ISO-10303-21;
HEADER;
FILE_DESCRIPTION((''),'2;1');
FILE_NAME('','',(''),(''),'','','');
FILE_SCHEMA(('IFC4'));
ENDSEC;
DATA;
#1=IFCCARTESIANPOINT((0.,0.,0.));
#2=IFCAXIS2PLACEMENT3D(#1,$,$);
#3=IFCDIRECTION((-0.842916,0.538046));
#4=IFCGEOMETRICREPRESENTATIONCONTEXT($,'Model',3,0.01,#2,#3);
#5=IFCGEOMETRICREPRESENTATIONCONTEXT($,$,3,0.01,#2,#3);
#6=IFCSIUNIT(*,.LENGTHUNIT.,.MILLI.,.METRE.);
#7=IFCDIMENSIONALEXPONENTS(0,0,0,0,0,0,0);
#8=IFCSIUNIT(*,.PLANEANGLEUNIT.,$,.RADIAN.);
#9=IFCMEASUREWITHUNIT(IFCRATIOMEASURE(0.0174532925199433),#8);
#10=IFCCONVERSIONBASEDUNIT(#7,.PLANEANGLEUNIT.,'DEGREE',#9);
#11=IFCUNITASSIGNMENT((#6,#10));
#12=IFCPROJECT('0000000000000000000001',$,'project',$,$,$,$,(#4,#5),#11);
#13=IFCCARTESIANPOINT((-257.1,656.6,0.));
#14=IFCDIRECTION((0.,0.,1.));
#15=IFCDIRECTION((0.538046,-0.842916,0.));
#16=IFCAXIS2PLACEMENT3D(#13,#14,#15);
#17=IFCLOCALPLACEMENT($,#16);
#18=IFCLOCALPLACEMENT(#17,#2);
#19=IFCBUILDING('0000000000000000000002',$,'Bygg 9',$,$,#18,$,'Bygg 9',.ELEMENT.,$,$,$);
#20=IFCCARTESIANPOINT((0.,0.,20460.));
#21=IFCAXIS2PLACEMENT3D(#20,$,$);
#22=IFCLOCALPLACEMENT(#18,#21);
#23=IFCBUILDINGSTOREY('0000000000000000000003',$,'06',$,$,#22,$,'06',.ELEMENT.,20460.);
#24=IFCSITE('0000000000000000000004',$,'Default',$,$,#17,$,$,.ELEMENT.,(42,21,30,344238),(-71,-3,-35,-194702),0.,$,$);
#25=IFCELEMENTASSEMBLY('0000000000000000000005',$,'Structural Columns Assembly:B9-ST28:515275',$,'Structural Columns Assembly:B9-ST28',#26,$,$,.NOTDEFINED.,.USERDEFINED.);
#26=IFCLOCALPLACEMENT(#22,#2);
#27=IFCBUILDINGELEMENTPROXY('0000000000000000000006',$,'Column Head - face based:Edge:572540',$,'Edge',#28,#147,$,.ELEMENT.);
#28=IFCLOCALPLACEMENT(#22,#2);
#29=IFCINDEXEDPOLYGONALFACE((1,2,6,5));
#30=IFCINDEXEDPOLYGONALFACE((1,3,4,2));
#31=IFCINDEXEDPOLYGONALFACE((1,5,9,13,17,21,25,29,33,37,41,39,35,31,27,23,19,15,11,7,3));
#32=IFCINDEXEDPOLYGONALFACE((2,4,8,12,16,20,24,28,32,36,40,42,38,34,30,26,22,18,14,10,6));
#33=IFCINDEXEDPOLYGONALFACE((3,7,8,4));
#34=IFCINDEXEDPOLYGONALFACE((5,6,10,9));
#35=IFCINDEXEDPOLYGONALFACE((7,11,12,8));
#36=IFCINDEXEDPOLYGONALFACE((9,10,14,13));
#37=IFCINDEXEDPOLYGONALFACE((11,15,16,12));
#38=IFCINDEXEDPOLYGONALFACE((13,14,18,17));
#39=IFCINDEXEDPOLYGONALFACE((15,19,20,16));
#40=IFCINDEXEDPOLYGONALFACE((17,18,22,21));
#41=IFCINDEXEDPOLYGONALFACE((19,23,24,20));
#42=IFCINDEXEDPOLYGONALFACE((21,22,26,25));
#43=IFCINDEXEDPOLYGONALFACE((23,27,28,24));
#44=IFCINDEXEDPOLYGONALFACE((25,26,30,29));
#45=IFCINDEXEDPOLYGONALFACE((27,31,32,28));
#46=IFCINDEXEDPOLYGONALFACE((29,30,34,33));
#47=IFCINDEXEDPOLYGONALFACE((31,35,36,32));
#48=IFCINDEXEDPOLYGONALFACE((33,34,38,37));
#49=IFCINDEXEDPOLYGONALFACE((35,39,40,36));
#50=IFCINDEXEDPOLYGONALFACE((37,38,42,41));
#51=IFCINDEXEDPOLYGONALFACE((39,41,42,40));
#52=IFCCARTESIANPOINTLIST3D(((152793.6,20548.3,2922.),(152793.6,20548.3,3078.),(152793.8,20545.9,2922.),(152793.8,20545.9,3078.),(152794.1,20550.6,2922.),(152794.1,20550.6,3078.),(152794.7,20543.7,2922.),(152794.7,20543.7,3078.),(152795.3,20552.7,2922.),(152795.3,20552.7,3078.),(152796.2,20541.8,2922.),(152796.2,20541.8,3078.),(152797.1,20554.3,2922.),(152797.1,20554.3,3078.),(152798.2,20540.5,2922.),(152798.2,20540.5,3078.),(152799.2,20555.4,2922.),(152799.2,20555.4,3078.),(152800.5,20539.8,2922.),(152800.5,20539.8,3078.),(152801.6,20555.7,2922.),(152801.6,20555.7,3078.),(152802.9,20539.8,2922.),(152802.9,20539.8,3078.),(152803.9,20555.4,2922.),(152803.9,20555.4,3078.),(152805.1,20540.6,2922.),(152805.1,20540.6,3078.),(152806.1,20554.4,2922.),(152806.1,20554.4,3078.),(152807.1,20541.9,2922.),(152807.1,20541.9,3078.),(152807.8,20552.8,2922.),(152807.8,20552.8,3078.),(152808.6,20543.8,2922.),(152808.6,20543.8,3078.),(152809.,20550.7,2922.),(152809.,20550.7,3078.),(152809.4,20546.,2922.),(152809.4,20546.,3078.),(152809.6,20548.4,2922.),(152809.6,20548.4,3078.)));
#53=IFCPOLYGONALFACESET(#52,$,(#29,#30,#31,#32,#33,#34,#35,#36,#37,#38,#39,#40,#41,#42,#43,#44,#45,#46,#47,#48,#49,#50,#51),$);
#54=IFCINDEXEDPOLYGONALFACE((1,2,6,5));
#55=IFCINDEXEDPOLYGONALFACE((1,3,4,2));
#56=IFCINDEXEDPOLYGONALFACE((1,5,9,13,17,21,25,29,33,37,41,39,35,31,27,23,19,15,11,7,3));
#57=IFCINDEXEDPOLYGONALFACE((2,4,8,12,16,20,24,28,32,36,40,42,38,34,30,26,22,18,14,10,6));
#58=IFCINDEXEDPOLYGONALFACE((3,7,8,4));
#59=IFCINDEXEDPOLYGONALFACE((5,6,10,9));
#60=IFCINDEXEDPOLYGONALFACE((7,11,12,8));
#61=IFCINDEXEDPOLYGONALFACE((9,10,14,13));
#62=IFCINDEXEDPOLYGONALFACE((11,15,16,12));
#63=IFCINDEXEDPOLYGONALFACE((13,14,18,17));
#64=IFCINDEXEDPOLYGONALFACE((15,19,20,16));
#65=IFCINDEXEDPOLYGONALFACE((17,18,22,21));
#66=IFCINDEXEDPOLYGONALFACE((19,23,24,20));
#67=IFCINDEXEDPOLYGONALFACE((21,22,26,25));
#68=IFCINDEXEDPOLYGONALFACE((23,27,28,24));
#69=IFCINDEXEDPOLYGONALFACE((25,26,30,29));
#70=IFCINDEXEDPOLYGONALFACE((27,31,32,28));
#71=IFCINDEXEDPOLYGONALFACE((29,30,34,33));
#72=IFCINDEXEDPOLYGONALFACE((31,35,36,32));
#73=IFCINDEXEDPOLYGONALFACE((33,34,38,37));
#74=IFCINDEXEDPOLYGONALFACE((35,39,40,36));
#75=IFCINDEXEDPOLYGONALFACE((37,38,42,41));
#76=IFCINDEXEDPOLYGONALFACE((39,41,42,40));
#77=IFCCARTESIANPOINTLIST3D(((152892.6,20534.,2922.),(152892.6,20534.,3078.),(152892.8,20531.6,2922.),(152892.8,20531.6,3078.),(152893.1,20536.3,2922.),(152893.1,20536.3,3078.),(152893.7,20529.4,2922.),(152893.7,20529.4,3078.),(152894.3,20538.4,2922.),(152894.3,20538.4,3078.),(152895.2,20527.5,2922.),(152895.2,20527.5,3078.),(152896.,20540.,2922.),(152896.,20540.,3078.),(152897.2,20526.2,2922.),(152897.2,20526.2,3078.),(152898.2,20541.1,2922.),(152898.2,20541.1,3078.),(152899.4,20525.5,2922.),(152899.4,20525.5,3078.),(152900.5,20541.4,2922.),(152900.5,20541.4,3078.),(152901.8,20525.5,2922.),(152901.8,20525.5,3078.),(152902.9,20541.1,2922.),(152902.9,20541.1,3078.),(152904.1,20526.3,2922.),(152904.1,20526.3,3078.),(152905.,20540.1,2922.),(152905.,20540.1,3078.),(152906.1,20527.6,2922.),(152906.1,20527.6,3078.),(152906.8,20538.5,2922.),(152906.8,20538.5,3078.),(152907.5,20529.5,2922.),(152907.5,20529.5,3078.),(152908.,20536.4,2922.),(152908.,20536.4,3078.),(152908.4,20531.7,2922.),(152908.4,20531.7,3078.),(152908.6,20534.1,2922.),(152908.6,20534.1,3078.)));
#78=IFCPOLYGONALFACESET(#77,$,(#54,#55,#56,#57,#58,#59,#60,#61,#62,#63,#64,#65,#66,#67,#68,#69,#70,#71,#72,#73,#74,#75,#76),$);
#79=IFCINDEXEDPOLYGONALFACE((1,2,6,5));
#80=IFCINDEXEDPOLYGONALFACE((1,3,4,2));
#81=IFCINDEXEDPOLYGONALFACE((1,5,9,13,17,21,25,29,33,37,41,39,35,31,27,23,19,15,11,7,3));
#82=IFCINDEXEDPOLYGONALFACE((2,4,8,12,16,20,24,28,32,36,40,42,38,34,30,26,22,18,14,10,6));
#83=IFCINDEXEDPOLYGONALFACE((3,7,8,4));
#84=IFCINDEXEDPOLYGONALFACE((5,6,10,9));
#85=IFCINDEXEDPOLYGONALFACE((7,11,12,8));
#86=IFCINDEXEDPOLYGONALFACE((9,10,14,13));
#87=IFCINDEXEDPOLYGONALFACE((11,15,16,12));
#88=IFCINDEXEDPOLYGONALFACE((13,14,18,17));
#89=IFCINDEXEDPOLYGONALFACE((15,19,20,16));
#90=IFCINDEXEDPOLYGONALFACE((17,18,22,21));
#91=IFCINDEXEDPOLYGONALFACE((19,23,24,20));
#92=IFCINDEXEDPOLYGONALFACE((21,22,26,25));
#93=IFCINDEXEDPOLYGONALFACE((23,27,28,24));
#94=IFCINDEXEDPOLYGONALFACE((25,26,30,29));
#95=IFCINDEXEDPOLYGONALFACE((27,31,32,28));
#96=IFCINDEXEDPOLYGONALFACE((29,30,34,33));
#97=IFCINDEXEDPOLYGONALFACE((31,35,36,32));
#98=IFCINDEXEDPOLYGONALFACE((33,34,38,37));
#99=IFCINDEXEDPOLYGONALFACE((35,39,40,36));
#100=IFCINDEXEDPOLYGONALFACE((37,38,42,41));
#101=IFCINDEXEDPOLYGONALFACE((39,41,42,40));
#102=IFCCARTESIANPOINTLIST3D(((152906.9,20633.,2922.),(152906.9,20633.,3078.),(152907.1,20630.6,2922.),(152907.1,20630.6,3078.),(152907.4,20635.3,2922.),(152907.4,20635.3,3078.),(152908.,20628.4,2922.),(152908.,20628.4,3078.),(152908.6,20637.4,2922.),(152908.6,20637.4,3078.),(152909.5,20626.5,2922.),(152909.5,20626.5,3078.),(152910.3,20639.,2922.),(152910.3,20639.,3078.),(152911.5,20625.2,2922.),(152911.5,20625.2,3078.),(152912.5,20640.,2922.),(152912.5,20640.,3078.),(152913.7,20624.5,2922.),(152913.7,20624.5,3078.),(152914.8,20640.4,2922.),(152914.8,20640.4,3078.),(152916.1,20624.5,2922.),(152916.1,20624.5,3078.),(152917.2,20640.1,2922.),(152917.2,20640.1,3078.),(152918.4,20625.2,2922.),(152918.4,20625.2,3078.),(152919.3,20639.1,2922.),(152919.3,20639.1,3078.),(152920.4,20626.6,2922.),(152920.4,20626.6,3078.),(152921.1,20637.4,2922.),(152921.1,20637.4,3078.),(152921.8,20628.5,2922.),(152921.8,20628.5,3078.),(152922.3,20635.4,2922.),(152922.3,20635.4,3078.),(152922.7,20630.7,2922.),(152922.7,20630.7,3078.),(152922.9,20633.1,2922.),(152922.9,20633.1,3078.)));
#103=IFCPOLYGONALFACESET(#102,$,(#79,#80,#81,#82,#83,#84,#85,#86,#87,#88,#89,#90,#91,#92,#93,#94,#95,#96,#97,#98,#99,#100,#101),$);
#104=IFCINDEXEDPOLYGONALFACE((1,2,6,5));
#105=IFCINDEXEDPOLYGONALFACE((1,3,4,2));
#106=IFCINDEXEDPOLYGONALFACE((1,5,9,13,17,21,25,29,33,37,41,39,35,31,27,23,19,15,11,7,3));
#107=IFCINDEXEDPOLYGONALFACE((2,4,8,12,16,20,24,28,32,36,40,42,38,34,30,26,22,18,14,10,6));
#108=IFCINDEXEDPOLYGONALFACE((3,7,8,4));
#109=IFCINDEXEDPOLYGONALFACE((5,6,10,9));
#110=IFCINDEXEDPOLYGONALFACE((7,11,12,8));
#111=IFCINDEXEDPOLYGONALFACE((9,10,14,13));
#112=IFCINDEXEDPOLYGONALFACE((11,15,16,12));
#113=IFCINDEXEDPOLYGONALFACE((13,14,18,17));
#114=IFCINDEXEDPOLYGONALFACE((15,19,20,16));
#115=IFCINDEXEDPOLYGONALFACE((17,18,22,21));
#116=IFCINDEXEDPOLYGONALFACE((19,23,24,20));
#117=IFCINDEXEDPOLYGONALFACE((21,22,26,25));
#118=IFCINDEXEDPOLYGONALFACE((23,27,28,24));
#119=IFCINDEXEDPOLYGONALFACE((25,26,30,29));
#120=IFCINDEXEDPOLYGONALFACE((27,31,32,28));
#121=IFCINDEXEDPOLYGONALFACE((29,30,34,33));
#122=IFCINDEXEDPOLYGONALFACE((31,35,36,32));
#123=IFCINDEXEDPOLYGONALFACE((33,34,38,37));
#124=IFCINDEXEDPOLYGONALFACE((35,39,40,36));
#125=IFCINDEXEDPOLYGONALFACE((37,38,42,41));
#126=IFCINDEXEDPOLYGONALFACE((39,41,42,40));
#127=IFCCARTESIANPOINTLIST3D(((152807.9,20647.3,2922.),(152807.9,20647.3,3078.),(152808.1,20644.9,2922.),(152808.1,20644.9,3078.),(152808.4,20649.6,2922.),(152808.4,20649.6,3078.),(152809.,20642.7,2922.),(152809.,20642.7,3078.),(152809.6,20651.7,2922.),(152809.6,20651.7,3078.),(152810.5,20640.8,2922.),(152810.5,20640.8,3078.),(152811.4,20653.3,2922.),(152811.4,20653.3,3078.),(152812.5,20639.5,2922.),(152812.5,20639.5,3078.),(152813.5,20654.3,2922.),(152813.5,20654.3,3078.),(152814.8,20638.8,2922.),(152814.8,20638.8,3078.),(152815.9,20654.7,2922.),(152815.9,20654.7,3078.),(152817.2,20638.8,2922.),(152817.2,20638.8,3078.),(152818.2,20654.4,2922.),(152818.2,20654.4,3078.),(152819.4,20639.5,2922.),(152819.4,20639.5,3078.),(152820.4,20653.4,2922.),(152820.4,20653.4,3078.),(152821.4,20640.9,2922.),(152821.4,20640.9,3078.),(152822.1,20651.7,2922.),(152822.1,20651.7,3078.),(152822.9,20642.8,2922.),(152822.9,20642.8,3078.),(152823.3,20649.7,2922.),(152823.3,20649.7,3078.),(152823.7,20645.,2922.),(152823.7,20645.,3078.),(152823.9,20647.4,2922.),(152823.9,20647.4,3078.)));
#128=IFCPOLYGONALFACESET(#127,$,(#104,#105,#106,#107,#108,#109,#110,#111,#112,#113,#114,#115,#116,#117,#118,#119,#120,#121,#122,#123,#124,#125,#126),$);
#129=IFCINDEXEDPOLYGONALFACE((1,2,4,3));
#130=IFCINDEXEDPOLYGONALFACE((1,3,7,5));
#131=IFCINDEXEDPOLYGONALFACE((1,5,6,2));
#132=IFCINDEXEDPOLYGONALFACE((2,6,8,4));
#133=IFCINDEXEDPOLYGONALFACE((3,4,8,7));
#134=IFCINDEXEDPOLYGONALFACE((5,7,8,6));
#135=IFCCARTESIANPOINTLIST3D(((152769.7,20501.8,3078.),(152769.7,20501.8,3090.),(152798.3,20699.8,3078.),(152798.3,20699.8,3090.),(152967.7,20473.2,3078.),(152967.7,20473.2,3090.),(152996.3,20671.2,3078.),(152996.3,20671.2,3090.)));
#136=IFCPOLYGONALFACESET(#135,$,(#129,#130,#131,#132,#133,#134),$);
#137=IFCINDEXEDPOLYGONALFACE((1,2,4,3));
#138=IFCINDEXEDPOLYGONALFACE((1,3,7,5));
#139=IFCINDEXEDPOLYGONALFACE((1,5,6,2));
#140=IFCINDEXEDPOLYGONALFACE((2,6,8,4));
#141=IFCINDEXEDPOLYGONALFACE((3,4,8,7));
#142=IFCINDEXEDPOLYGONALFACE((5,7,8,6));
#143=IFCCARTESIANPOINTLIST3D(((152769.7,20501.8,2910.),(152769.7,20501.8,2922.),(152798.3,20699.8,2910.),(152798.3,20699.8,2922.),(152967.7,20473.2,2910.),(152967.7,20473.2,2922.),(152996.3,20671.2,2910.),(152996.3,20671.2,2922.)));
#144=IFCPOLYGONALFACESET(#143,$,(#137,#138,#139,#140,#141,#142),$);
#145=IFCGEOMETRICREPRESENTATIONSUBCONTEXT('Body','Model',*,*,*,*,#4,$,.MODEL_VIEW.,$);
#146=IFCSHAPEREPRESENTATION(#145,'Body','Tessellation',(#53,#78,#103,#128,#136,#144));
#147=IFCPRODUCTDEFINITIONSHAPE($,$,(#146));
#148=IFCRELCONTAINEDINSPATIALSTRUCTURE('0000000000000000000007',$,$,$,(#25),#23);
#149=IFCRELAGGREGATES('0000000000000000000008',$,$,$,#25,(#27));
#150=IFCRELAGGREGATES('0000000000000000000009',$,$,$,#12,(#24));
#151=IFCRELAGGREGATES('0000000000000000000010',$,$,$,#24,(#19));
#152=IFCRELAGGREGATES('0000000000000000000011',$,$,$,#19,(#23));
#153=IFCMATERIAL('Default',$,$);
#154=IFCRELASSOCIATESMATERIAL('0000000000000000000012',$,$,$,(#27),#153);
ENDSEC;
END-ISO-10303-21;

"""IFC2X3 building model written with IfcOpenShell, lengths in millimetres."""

from ifc_helpers import new_model, entity, si_unit, converted_unit, direction, frame, frame_2d, origin, origin_2d_with_axis, place, context, subcontext, project, spatial, rectangle, circle, extrude, source, transform, mapped, material, element, aggregate, save


model = new_model("IFC2X3")

# Units and contexts
model_context = context("Model", 3, precision=0.01, world=origin(), true_north=direction((-0.842916, 0.538046)))
context_of_model = context(None, 3, precision=0.01, world=origin(), true_north=direction((-0.842916, 0.538046)))
body_context = subcontext(model_context, "Body", "Model", "MODEL_VIEW")
ifc_project = project(units=[si_unit("LENGTHUNIT", "METRE", prefix="MILLI"), converted_unit("PLANEANGLEUNIT", "DEGREE", entity("IfcRatioMeasure", 0.0174532925199433), si_unit("PLANEANGLEUNIT", "RADIAN"), dimensions=[0, 0, 0, 0, 0, 0, 0])], contexts=[model_context, context_of_model])

# Site, building, storey
site_placement = place(None, frame((-257.1, 656.6, 0.0), z_axis=(0.0, 0.0, 1.0), x_axis=(0.538046, -0.842916, 0.0)))
site = spatial("IfcSite", under=ifc_project, at=site_placement, Name="Default", CompositionType="ELEMENT", RefLatitude=(42, 21, 30, 344238), RefLongitude=(-71, -3, -35, -194702), RefElevation=0.0)
building_placement = place(site_placement, origin())
building = spatial("IfcBuilding", under=site, at=building_placement, Name="Bygg 9", LongName="Bygg 9", CompositionType="ELEMENT")
storey_placement = place(building_placement, frame((0.0, 0.0, 20460.0)))
storey = spatial("IfcBuildingStorey", under=building, at=storey_placement, Name="06", LongName="06", CompositionType="ELEMENT", Elevation=20460.0)

# Element assembly
assembly_1_placement = place(storey_placement, origin())
assembly_1 = element("IfcElementAssembly", 1, at=assembly_1_placement, inside=storey, Name="Structural Columns Assembly:B9-ST28:515275", ObjectType="Structural Columns Assembly:B9-ST28", AssemblyPlace="NOTDEFINED", PredefinedType="USERDEFINED")

# Shared definitions
ifc_material_1 = material(Name="Default")

# Building element proxy
shared_shape_1 = source(origin(), body_context, "Body", "SweptSolid", [
    extrude(circle(Radius=8.0, at=frame_2d((0.0, 0.0), x_axis=(1.0, 0.0))), frame((50.0, -75.0, 12.0)), (0.0, 0.0, 1.0), 156.0),
    extrude(circle(Radius=8.0, at=frame_2d((0.0, 0.0), x_axis=(1.0, 0.0))), frame((50.0, 25.0, 12.0)), (0.0, 0.0, 1.0), 156.0),
    extrude(circle(Radius=8.0, at=frame_2d((0.0, 0.0), x_axis=(1.0, 0.0))), frame((-50.0, 25.0, 12.0)), (0.0, 0.0, 1.0), 156.0),
    extrude(circle(Radius=8.0, at=frame_2d((0.0, 0.0), x_axis=(1.0, 0.0))), frame((-50.0, -75.0, 12.0)), (0.0, 0.0, 1.0), 156.0),
    extrude(rectangle(XDim=200.0, YDim=200.0, at=origin_2d_with_axis()), frame((0.0, 0.0, 168.0), z_axis=(0.0, 0.0, 1.0), x_axis=(-1.0, 0.0, 0.0)), (0.0, 0.0, 1.0), 12.0),
    extrude(rectangle(XDim=200.0, YDim=200.0, at=origin_2d_with_axis()), frame((0.0, 0.0, 0.0), z_axis=(0.0, 0.0, 1.0), x_axis=(0.0, 1.0, 0.0)), (0.0, 0.0, 1.0), 12.0),
])
proxy_1_placement = place(assembly_1_placement, frame((152883.0, 20586.5, 2910.0), z_axis=(0.0, 0.0, 1.0), x_axis=(-0.142999, -0.989723, 0.0)))
proxy_1 = element("IfcBuildingElementProxy", 2, at=proxy_1_placement, material=ifc_material_1, Name="Column Head - face based:Edge:572540", ObjectType="Edge", CompositionType="ELEMENT", context=body_context, shape_type="MappedRepresentation", body=[
    mapped(shared_shape_1, transform((0.0, 0.0, 0.0), scale=1.0)),
])
aggregate(assembly_1, [proxy_1])

save(model, "model.ifc")
